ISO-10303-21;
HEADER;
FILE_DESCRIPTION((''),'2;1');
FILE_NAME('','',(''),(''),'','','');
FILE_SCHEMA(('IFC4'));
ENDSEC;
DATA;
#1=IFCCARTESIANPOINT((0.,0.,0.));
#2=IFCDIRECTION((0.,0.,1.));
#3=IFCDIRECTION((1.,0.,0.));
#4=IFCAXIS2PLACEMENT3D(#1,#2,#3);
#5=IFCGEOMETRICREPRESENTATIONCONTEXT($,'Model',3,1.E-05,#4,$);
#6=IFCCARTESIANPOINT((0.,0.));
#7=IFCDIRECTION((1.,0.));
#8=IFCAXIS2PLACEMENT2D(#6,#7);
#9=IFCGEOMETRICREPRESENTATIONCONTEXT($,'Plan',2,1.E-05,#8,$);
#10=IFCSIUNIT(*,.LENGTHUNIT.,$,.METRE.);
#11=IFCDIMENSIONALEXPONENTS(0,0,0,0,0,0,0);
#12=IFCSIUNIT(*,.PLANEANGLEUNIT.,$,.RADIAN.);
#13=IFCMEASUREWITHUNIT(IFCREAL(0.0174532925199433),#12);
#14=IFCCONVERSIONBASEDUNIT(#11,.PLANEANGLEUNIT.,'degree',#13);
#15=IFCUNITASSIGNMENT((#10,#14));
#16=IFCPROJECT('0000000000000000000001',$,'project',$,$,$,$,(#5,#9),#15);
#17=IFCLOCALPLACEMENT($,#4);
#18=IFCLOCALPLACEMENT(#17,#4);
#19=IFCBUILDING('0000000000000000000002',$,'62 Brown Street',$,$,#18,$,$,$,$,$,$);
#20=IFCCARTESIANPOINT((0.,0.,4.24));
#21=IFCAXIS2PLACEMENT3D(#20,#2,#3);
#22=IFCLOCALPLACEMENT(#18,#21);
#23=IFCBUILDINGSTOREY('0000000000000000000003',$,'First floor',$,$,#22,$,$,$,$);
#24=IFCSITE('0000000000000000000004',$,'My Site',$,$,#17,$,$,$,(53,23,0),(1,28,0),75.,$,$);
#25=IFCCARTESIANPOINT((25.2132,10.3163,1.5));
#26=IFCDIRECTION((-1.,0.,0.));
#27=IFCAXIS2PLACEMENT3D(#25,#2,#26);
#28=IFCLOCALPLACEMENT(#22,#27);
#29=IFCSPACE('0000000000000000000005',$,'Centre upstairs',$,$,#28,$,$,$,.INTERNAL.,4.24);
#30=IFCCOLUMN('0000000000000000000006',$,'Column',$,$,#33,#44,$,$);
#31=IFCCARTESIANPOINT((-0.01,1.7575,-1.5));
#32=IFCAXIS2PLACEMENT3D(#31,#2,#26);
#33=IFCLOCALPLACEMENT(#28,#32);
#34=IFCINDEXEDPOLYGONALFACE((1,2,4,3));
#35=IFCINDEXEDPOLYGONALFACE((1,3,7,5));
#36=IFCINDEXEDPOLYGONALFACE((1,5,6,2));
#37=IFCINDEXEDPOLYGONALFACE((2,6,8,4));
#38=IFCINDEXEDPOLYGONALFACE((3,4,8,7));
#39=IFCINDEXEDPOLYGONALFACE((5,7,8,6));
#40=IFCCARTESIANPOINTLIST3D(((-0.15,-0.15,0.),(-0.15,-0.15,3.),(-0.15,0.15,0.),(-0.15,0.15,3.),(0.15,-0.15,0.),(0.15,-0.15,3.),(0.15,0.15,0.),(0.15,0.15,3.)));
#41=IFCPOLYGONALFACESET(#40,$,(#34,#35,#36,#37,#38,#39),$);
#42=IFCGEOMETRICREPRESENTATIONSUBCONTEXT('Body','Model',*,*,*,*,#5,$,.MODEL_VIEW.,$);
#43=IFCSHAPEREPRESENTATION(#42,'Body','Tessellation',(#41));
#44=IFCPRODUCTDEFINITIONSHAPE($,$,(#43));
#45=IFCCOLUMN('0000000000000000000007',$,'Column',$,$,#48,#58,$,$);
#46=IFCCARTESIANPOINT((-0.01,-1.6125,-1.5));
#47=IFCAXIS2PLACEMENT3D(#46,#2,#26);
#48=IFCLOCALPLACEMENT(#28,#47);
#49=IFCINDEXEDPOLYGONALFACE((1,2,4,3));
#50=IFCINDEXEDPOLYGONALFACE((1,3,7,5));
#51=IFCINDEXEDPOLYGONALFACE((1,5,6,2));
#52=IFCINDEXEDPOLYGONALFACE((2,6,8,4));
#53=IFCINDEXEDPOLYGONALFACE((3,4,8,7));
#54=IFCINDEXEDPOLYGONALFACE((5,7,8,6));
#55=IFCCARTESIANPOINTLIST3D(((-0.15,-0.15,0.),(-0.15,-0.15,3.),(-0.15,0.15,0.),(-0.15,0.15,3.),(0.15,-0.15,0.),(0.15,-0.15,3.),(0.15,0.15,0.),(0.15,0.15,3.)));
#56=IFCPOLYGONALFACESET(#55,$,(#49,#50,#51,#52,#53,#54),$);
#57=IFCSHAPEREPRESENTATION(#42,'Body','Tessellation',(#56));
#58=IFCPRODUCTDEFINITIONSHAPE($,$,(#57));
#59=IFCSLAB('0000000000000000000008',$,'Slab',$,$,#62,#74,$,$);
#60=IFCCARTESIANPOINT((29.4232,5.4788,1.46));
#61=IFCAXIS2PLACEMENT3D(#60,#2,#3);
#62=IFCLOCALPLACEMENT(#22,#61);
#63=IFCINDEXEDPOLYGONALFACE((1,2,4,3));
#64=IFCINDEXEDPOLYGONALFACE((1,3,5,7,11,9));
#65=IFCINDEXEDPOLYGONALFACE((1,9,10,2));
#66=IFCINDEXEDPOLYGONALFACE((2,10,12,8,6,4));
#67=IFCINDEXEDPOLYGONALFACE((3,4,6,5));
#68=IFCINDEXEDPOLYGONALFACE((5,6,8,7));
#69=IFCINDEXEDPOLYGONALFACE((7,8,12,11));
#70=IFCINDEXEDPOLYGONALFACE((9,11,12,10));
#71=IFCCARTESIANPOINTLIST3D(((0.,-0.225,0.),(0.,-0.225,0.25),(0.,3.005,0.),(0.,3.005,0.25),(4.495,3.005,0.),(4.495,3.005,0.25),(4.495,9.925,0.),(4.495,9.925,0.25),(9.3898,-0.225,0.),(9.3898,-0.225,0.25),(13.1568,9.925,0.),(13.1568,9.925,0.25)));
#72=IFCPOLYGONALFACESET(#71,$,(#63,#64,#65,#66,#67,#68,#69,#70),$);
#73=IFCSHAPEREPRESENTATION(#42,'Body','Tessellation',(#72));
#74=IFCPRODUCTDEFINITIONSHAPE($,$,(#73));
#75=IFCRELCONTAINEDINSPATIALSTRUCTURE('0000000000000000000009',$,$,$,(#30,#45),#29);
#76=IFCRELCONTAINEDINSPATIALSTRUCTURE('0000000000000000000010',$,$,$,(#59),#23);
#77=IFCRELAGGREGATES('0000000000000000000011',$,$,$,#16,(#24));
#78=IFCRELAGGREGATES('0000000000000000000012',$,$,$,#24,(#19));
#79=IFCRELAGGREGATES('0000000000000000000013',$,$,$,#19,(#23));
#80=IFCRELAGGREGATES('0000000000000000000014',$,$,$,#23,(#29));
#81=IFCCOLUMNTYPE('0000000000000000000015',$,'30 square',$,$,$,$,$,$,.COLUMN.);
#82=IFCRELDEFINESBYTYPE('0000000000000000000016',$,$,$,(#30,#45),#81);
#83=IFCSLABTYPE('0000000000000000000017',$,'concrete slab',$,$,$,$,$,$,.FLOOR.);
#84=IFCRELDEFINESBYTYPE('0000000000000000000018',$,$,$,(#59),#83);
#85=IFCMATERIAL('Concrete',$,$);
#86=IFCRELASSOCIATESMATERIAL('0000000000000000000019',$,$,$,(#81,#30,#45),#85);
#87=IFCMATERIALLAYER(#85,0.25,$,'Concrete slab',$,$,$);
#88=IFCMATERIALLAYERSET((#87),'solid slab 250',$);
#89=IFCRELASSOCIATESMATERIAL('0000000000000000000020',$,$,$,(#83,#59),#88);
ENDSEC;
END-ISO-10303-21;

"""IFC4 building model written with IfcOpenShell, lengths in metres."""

from ifc_helpers import new_model, entity, si_unit, converted_unit, frame, origin_with_axes, origin_2d_with_axis, place, context, subcontext, project, spatial, line, indexed_curve, rectangle, outline, extrude, material, layer, layer_set, layer_usage, material_profile, profile_set, profile_usage, type_object, element, save


model = new_model("IFC4")

# Units and contexts
model_context = context("Model", 3, precision=1e-05, world=origin_with_axes())
plan_context = context("Plan", 2, precision=1e-05, world=origin_2d_with_axis())
body_context_1 = subcontext(model_context, "Body", "Model", "MODEL_VIEW")
ifc_project = project(units=[si_unit("LENGTHUNIT", "METRE"), converted_unit("PLANEANGLEUNIT", "degree", entity("IfcReal", 0.0174532925199433), si_unit("PLANEANGLEUNIT", "RADIAN"), dimensions=[0, 0, 0, 0, 0, 0, 0])], contexts=[model_context, plan_context])

# Site, building, storey, space
site_placement = place(None, origin_with_axes())
site = spatial("IfcSite", under=ifc_project, at=site_placement, Name="My Site", RefLatitude=(53, 23, 0), RefLongitude=(1, 28, 0), RefElevation=75.0)
building_placement = place(site_placement, origin_with_axes())
building = spatial("IfcBuilding", under=site, at=building_placement, Name="62 Brown Street")
storey_placement = place(building_placement, frame((0.0, 0.0, 4.24), z_axis=(0.0, 0.0, 1.0), x_axis=(1.0, 0.0, 0.0)))
storey = spatial("IfcBuildingStorey", under=building, at=storey_placement, Name="First floor")
space_placement = place(storey_placement, frame((25.2132, 10.3163, 1.5), z_axis=(0.0, 0.0, 1.0), x_axis=(-1.0, 0.0, 0.0)))
space = spatial("IfcSpace", under=storey, at=space_placement, Name="Centre upstairs", PredefinedType="INTERNAL", ElevationWithFlooring=4.24)

# Columns
ifc_material_1 = material(Name="Concrete")
ifc_material_profile = material_profile(ifc_material_1, rectangle(XDim=0.3, YDim=0.3))
ifc_profile_set = profile_set([ifc_material_profile])
ifc_profile_usage_1 = profile_usage(ifc_profile_set, cardinal=5)
column_type = type_object("IfcColumnType", Name="30 square", PredefinedType="COLUMN", material=ifc_profile_set)
column_1_placement = place(space_placement, frame((-0.01, 1.7575, -1.5), z_axis=(0.0, 0.0, 1.0), x_axis=(-1.0, 0.0, 0.0)))
element("IfcColumn", 1, at=column_1_placement, inside=space, type_object=column_type, material=ifc_profile_usage_1, Name="Column", context=body_context_1, shape_type="SweptSolid", body=[
    extrude(rectangle(XDim=0.3, YDim=0.3), origin_with_axes(), (0.0, 0.0, 1.0), 3.0),
])
ifc_profile_usage_2 = profile_usage(ifc_profile_set, cardinal=5)
column_2_placement = place(space_placement, frame((-0.01, -1.6125, -1.5), z_axis=(0.0, 0.0, 1.0), x_axis=(-1.0, 0.0, 0.0)))
element("IfcColumn", 2, at=column_2_placement, inside=space, type_object=column_type, material=ifc_profile_usage_2, Name="Column", context=body_context_1, shape_type="SweptSolid", body=[
    extrude(rectangle(XDim=0.3, YDim=0.3), origin_with_axes(), (0.0, 0.0, 1.0), 3.0),
])

# Slab
ifc_layer_1 = layer(ifc_material_1, 0.25, Name="Concrete slab")
ifc_layer_set_1 = layer_set([ifc_layer_1], Name="solid slab 250")
slab_type = type_object("IfcSlabType", Name="concrete slab", PredefinedType="FLOOR", material=ifc_layer_set_1)
ifc_layer_usage_1 = layer_usage(ifc_layer_set_1, "AXIS3", "POSITIVE", 0.0)
slab_1_placement = place(storey_placement, frame((29.4232, 5.4788, 1.46), z_axis=(0.0, 0.0, 1.0), x_axis=(1.0, 0.0, 0.0)))
element("IfcSlab", 3, at=slab_1_placement, inside=storey, type_object=slab_type, material=ifc_layer_usage_1, Name="Slab", context=body_context_1, shape_type="SweptSolid", body=[
    extrude(outline(indexed_curve([(0.0, 3.005), (0.0, -0.225), (9.3898, -0.225), (13.1568, 9.925), (4.495, 9.925), (4.495, 3.005)], segments=[line(4, 3), line(3, 2), line(2, 1), line(1, 6), line(6, 5), line(5, 4)], self_intersect=False)), None, (0.0, 0.0, 1.0), 0.25),
])

save(model, "model.ifc")
